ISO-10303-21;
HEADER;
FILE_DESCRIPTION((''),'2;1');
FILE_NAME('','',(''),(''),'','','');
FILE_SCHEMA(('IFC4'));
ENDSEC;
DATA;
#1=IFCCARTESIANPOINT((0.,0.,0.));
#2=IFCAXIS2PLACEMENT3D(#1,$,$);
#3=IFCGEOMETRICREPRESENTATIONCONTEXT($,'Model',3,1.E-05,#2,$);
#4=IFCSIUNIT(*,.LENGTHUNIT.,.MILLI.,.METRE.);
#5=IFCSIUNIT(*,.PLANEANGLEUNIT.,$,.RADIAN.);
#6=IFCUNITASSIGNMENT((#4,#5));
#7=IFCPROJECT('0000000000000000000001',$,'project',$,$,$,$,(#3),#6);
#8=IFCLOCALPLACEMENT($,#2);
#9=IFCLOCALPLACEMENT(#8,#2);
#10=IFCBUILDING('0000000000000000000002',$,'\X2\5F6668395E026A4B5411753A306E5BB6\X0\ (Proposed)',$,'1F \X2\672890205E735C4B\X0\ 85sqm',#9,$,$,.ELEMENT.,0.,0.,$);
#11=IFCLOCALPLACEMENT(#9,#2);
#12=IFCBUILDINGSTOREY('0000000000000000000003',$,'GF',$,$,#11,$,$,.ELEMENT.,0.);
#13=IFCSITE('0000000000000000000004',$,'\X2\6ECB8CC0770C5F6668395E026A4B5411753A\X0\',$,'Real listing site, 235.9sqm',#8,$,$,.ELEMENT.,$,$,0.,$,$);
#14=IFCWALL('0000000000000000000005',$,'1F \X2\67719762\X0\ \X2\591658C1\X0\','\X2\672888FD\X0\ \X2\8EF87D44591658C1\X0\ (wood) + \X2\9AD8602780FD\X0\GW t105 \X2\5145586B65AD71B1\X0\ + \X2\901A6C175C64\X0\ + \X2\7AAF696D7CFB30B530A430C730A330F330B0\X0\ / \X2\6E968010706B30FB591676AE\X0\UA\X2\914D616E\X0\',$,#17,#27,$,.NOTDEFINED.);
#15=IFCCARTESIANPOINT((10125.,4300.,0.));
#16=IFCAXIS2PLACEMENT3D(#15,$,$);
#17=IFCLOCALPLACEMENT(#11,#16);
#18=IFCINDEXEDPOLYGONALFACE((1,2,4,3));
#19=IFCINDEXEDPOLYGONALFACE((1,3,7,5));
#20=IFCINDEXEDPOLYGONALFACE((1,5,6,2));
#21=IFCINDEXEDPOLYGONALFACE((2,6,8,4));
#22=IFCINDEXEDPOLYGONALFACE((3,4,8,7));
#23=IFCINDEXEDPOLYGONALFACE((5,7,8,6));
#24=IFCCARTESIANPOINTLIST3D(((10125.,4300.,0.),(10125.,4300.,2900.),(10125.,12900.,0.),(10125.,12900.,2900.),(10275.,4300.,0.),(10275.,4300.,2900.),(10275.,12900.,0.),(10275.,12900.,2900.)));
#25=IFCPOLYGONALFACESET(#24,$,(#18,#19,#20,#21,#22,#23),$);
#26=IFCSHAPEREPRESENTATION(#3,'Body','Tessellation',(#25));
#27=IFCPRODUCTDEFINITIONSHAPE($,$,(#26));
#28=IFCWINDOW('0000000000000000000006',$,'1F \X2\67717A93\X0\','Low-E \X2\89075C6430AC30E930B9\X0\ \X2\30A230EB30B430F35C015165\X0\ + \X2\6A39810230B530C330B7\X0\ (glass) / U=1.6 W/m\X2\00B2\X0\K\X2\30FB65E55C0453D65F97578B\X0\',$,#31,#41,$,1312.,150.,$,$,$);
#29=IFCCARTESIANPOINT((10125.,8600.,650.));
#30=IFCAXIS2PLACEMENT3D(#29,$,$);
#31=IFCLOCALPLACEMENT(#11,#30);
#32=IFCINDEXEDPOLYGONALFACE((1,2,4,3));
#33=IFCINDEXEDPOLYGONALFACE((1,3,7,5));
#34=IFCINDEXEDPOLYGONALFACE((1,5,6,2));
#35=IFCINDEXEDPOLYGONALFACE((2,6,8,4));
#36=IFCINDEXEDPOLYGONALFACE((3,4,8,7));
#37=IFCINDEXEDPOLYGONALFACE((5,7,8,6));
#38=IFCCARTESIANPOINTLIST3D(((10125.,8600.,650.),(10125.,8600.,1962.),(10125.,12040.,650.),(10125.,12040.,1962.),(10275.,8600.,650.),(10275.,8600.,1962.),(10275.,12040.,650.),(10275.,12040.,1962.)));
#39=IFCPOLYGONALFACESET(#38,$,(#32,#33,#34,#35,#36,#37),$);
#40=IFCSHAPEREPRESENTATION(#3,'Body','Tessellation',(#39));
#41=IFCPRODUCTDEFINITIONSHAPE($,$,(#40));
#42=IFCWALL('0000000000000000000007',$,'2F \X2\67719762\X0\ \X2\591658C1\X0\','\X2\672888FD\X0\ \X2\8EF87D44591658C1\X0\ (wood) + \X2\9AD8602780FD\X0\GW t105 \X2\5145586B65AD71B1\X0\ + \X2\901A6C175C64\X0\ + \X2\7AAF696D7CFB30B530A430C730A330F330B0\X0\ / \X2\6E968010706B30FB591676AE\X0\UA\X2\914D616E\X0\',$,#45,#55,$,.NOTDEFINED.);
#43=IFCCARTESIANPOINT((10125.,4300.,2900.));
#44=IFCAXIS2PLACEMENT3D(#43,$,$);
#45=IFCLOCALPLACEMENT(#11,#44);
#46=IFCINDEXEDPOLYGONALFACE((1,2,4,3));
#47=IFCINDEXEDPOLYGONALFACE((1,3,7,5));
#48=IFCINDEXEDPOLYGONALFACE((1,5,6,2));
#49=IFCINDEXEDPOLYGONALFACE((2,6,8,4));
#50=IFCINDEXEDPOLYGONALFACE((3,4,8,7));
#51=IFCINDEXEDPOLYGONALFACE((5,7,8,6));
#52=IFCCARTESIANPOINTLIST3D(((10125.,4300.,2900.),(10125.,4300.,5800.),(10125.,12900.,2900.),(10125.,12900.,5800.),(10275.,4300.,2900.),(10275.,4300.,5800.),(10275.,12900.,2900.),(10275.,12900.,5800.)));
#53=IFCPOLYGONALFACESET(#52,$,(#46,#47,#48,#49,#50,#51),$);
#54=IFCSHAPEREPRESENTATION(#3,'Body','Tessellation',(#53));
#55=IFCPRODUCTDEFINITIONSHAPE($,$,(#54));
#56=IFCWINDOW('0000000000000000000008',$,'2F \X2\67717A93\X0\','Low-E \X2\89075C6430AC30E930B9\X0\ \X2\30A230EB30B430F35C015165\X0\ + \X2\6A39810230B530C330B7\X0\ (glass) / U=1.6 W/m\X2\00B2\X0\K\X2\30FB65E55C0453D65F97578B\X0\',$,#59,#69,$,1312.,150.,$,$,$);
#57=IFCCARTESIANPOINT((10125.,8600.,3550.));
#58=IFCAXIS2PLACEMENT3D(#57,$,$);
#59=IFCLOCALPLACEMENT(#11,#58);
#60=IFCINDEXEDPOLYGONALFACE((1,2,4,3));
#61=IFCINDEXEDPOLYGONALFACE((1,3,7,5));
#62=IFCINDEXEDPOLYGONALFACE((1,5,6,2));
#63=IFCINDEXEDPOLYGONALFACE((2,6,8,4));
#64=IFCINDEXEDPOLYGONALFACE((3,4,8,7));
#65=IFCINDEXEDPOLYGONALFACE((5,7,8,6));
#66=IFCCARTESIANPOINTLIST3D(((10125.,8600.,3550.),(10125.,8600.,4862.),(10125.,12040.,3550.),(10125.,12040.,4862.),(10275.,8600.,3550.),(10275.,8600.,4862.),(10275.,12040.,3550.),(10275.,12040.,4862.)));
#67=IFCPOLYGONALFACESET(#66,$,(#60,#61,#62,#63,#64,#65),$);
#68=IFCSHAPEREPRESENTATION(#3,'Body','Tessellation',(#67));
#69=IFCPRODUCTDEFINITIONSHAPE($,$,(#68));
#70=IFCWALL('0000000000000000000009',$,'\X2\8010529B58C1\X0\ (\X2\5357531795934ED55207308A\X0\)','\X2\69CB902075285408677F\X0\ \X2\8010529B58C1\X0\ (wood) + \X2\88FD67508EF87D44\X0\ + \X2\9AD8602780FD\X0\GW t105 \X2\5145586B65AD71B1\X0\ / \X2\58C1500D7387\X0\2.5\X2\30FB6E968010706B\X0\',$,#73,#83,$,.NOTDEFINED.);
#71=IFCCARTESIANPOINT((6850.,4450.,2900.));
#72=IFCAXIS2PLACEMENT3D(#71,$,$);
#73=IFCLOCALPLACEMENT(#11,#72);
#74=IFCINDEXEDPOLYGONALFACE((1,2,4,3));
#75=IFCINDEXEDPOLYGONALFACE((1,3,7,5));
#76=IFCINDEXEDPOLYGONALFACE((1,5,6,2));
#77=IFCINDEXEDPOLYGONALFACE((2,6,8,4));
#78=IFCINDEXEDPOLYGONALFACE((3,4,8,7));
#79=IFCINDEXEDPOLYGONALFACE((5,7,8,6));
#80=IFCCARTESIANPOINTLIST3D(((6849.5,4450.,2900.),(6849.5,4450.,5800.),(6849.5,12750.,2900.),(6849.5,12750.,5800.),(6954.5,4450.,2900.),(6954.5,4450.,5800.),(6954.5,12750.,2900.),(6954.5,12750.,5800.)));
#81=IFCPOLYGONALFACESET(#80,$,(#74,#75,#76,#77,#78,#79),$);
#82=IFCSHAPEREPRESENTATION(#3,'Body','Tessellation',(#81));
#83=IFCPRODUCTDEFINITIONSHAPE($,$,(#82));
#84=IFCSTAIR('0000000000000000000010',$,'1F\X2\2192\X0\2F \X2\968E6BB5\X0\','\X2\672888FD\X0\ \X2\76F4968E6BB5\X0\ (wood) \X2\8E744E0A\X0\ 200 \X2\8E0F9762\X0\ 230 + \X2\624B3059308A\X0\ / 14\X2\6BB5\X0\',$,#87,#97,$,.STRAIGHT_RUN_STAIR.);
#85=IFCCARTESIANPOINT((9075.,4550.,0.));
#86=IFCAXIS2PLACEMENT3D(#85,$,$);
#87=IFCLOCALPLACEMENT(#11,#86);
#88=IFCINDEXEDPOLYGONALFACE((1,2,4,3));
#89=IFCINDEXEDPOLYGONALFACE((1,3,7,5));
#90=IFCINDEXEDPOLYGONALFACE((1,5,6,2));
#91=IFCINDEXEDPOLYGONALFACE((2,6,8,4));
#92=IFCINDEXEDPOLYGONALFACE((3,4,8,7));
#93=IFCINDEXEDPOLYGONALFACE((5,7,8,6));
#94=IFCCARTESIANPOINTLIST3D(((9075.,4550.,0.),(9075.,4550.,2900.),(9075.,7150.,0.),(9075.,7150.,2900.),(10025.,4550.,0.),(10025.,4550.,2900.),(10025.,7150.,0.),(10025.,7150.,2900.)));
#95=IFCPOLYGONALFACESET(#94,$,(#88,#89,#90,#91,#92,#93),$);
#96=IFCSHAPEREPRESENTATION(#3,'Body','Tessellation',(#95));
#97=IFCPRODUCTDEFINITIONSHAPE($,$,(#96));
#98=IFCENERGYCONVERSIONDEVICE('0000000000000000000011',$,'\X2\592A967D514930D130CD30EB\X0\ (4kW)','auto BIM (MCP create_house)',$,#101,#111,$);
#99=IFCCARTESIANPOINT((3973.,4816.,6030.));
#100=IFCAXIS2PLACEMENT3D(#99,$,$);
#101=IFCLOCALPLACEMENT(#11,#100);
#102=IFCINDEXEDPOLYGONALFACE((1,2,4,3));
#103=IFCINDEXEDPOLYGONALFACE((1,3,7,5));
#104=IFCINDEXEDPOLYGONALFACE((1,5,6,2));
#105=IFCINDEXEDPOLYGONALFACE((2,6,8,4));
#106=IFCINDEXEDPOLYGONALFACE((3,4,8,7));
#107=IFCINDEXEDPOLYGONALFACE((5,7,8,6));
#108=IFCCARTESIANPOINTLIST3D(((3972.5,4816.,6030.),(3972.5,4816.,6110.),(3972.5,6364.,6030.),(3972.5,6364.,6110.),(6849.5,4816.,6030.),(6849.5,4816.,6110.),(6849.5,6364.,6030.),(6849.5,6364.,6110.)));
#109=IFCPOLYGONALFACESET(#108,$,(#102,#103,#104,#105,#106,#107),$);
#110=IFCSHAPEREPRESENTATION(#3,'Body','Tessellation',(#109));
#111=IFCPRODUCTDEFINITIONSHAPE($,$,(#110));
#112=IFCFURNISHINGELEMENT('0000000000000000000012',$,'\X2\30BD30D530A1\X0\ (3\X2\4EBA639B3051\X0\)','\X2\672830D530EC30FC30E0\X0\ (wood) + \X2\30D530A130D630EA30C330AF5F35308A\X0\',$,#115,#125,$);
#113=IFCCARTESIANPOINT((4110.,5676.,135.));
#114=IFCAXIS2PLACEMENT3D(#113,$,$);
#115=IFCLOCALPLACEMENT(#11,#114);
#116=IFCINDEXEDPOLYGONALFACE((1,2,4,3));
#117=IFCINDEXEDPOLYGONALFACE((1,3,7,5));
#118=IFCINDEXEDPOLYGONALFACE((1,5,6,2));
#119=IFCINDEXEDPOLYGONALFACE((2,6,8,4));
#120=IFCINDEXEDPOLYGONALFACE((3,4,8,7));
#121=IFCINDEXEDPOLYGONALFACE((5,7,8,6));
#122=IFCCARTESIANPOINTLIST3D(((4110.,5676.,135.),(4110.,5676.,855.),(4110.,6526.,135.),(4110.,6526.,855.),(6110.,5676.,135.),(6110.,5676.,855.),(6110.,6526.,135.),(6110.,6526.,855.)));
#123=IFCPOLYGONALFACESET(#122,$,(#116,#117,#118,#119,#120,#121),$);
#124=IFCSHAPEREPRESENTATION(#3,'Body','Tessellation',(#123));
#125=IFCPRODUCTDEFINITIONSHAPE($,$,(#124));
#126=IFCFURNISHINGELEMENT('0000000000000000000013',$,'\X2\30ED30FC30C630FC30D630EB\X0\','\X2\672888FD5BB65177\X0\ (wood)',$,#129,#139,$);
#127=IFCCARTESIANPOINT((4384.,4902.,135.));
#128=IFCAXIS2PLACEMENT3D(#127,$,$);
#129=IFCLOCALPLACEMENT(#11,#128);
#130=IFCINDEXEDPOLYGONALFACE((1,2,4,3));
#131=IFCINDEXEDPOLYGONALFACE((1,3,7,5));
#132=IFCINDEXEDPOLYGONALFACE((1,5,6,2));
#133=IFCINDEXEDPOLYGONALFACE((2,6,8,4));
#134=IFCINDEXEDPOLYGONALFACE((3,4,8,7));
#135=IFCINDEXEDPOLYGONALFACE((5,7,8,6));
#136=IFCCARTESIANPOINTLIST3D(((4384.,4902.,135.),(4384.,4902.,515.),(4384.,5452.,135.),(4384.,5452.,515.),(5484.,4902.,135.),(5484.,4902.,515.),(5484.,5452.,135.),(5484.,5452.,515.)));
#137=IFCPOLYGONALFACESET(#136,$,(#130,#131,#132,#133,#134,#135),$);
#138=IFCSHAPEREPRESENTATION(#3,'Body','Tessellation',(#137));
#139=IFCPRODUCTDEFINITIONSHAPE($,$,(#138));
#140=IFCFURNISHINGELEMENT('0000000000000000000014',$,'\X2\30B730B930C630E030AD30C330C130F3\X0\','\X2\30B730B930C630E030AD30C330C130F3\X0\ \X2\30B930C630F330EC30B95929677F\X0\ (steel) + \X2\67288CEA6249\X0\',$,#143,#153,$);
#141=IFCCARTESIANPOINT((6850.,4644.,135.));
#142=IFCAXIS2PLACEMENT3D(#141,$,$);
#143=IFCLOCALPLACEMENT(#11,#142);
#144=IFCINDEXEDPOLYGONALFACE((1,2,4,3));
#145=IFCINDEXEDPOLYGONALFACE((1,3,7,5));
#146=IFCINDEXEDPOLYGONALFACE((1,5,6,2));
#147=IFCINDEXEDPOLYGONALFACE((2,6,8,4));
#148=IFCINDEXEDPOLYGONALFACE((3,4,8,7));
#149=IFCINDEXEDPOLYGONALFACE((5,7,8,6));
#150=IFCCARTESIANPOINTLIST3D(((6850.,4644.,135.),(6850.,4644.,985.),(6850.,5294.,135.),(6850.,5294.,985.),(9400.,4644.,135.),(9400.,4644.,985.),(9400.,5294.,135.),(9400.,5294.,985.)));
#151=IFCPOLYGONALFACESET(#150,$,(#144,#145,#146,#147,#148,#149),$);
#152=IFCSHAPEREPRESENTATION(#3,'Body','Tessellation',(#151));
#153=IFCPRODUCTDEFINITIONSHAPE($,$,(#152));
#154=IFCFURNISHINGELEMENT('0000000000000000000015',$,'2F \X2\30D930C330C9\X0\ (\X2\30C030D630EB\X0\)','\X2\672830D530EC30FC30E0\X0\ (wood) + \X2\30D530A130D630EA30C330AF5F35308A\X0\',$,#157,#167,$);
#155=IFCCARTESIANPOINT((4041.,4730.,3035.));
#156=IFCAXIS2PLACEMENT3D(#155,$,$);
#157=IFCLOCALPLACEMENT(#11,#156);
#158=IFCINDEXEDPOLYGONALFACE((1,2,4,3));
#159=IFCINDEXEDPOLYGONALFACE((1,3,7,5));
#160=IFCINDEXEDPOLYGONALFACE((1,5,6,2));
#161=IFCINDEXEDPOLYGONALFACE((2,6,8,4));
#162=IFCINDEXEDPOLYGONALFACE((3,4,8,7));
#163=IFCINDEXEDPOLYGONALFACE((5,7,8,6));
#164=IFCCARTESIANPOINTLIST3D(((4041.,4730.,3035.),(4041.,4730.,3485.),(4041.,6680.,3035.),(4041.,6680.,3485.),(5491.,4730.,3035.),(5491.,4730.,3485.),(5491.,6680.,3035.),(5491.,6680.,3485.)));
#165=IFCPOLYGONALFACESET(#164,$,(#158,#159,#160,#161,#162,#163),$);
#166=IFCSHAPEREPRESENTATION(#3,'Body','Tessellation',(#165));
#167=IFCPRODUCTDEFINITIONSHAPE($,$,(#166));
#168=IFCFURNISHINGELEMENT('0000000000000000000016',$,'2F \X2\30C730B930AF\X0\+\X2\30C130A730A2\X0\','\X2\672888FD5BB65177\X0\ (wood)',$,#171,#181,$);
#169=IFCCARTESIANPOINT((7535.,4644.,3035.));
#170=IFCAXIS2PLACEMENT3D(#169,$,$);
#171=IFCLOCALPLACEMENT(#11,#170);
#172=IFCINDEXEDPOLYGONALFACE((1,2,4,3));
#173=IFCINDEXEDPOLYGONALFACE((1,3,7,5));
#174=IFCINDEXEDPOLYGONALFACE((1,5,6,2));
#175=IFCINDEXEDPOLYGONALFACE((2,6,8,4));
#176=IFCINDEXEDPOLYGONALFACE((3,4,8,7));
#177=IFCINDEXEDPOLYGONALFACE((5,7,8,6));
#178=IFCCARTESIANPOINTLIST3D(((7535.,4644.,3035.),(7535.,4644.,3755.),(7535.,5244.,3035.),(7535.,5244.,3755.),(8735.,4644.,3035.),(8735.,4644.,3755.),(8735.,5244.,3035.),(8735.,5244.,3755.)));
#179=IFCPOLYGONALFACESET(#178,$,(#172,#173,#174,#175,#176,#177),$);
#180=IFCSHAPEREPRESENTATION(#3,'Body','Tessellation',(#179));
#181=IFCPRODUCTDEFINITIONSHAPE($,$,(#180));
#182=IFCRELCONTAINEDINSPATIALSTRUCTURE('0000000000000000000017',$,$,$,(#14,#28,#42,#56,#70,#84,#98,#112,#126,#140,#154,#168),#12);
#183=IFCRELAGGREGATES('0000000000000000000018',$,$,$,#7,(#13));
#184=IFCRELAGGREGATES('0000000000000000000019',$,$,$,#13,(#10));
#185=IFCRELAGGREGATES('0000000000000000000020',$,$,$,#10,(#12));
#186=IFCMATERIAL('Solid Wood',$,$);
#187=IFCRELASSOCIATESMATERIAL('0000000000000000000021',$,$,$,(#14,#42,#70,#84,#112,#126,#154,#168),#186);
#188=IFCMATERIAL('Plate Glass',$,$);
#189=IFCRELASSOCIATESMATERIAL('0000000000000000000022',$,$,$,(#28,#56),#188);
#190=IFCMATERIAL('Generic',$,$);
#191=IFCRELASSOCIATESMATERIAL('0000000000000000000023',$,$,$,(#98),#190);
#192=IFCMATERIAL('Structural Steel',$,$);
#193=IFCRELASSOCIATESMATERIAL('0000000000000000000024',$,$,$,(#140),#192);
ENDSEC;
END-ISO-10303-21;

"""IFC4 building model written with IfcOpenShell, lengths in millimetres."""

from ifc_helpers import new_model, si_unit, frame, frame_2d, origin, place, context, project, spatial, rectangle, extrude, material, element, fill, save


model = new_model("IFC4")

# Units and contexts
model_context = context("Model", 3, precision=1e-05, world=origin())
ifc_project = project(units=[si_unit("LENGTHUNIT", "METRE", prefix="MILLI"), si_unit("PLANEANGLEUNIT", "RADIAN")], contexts=[model_context])

# Site, building, storey
site_placement = place(None, origin())
site = spatial("IfcSite", under=ifc_project, at=site_placement, Name="滋賀県彦根市橋向町", ObjectType="Real listing site, 235.9sqm", CompositionType="ELEMENT", RefElevation=0.0)
building_placement = place(site_placement, origin())
building = spatial("IfcBuilding", under=site, at=building_placement, Name="彦根市橋向町の家 (Proposed)", ObjectType="1F 木造平屋 85sqm", CompositionType="ELEMENT", ElevationOfRefHeight=0.0, ElevationOfTerrain=0.0)
storey_placement = place(building_placement, origin())
storey = spatial("IfcBuildingStorey", under=building, at=storey_placement, Name="GF", CompositionType="ELEMENT", Elevation=0.0)

# Wall, opening, window
ifc_material_1 = material(Name="Solid Wood")
wall_1_placement = place(storey_placement, frame((10125.0, 4300.0, 0.0)))
wall_1 = element("IfcWall", 1, at=wall_1_placement, inside=storey, material=ifc_material_1, Name="1F 東面 外壁", Description="木製 軸組外壁 (wood) + 高性能GW t105 充填断熱 + 通気層 + 窯業系サイディング / 準耐火・外皮UA配慮", PredefinedType="NOTDEFINED", context=model_context, shape_type="SweptSolid", body=[
    extrude(rectangle(XDim=150.0, YDim=8600.0, at=frame_2d((75.0, 4300.0))), frame((10125.0, 4300.0, 0.0)), (0.0, 0.0, 1.0), 2900.0),
])
opening_1_placement = place(storey_placement, frame((10125.0, 8600.0, 650.0)))
opening_1 = element("IfcOpeningElement", 2, at=opening_1_placement, cuts=wall_1, PredefinedType="NOTDEFINED", context=model_context, shape_type="SweptSolid", body=[
    extrude(rectangle(XDim=150.0, YDim=3440.0, at=frame_2d((75.0, 1720.0))), frame((10125.0, 8600.0, 650.0)), (0.0, 0.0, 1.0), 1312.0),
])
ifc_material_2 = material(Name="Plate Glass")
window_1_placement = place(storey_placement, frame((10125.0, 8600.0, 650.0)))
window_1 = element("IfcWindow", 3, at=window_1_placement, inside=storey, material=ifc_material_2, Name="1F 東窓", Description="Low-E 複層ガラス アルゴン封入 + 樹脂サッシ (glass) / U=1.6 W/m²K・日射取得型", OverallHeight=1312.0, OverallWidth=150.0, context=model_context, shape_type="SweptSolid", body=[
    extrude(rectangle(XDim=150.0, YDim=3440.0, at=frame_2d((75.0, 1720.0))), frame((10125.0, 8600.0, 650.0)), (0.0, 0.0, 1.0), 1312.0),
])
fill(opening_1, window_1)

# Wall, opening, window
wall_2_placement = place(storey_placement, frame((10125.0, 4300.0, 2900.0)))
wall_2 = element("IfcWall", 4, at=wall_2_placement, inside=storey, material=ifc_material_1, Name="2F 東面 外壁", Description="木製 軸組外壁 (wood) + 高性能GW t105 充填断熱 + 通気層 + 窯業系サイディング / 準耐火・外皮UA配慮", PredefinedType="NOTDEFINED", context=model_context, shape_type="SweptSolid", body=[
    extrude(rectangle(XDim=150.0, YDim=8600.0, at=frame_2d((75.0, 4300.0))), frame((10125.0, 4300.0, 2900.0)), (0.0, 0.0, 1.0), 2900.0),
])
opening_2_placement = place(storey_placement, frame((10125.0, 8600.0, 3550.0)))
opening_2 = element("IfcOpeningElement", 5, at=opening_2_placement, cuts=wall_2, PredefinedType="NOTDEFINED", context=model_context, shape_type="SweptSolid", body=[
    extrude(rectangle(XDim=150.0, YDim=3440.0, at=frame_2d((75.0, 1720.0))), frame((10125.0, 8600.0, 3550.0)), (0.0, 0.0, 1.0), 1312.0),
])
window_2_placement = place(storey_placement, frame((10125.0, 8600.0, 3550.0)))
window_2 = element("IfcWindow", 6, at=window_2_placement, inside=storey, material=ifc_material_2, Name="2F 東窓", Description="Low-E 複層ガラス アルゴン封入 + 樹脂サッシ (glass) / U=1.6 W/m²K・日射取得型", OverallHeight=1312.0, OverallWidth=150.0, context=model_context, shape_type="SweptSolid", body=[
    extrude(rectangle(XDim=150.0, YDim=3440.0, at=frame_2d((75.0, 1720.0))), frame((10125.0, 8600.0, 3550.0)), (0.0, 0.0, 1.0), 1312.0),
])
fill(opening_2, window_2)

# Wall
wall_3_placement = place(storey_placement, frame((6850.0, 4450.0, 2900.0)))
element("IfcWall", 7, at=wall_3_placement, inside=storey, material=ifc_material_1, Name="耐力壁 (南北間仕切り)", Description="構造用合板 耐力壁 (wood) + 製材軸組 + 高性能GW t105 充填断熱 / 壁倍率2.5・準耐火", PredefinedType="NOTDEFINED", context=model_context, shape_type="SweptSolid", body=[
    extrude(rectangle(XDim=105.0, YDim=8300.0, at=frame_2d((52.0, 4150.0))), frame((6850.0, 4450.0, 2900.0)), (0.0, 0.0, 1.0), 2900.0),
])

# Stair
stair_placement = place(storey_placement, frame((9075.0, 4550.0, 0.0)))
element("IfcStair", 8, at=stair_placement, inside=storey, material=ifc_material_1, Name="1F→2F 階段", Description="木製 直階段 (wood) 蹴上 200 踏面 230 + 手すり / 14段", PredefinedType="STRAIGHT_RUN_STAIR", context=model_context, shape_type="SweptSolid", body=[
    extrude(rectangle(XDim=950.0, YDim=2600.0, at=frame_2d((475.0, 1300.0))), frame((9075.0, 4550.0, 0.0)), (0.0, 0.0, 1.0), 2900.0),
])

# Energy conversion device
ifc_material_3 = material(Name="Generic")
energy_conversion_device_placement = place(storey_placement, frame((3973.0, 4816.0, 6030.0)))
element("IfcEnergyConversionDevice", 9, at=energy_conversion_device_placement, inside=storey, material=ifc_material_3, Name="太陽光パネル (4kW)", Description="auto BIM (MCP create_house)", context=model_context, shape_type="SweptSolid", body=[
    extrude(rectangle(XDim=2877.0, YDim=1548.0, at=frame_2d((1438.0, 774.0))), frame((3973.0, 4816.0, 6030.0)), (0.0, 0.0, 1.0), 80.0),
])

# Furnishing elements
furnishing_1_placement = place(storey_placement, frame((4110.0, 5676.0, 135.0)))
element("IfcFurnishingElement", 10, at=furnishing_1_placement, inside=storey, material=ifc_material_1, Name="ソファ (3人掛け)", Description="木フレーム (wood) + ファブリック張り", context=model_context, shape_type="SweptSolid", body=[
    extrude(rectangle(XDim=2000.0, YDim=850.0, at=frame_2d((1000.0, 425.0))), frame((4110.0, 5676.0, 135.0)), (0.0, 0.0, 1.0), 720.0),
])
furnishing_2_placement = place(storey_placement, frame((4384.0, 4902.0, 135.0)))
element("IfcFurnishingElement", 11, at=furnishing_2_placement, inside=storey, material=ifc_material_1, Name="ローテーブル", Description="木製家具 (wood)", context=model_context, shape_type="SweptSolid", body=[
    extrude(rectangle(XDim=1100.0, YDim=550.0, at=frame_2d((550.0, 275.0))), frame((4384.0, 4902.0, 135.0)), (0.0, 0.0, 1.0), 380.0),
])
ifc_material_4 = material(Name="Structural Steel")
furnishing_3_placement = place(storey_placement, frame((6850.0, 4644.0, 135.0)))
element("IfcFurnishingElement", 12, at=furnishing_3_placement, inside=storey, material=ifc_material_4, Name="システムキッチン", Description="システムキッチン ステンレス天板 (steel) + 木質扉", context=model_context, shape_type="SweptSolid", body=[
    extrude(rectangle(XDim=2550.0, YDim=650.0, at=frame_2d((1275.0, 325.0))), frame((6850.0, 4644.0, 135.0)), (0.0, 0.0, 1.0), 850.0),
])
furnishing_4_placement = place(storey_placement, frame((4041.0, 4730.0, 3035.0)))
element("IfcFurnishingElement", 13, at=furnishing_4_placement, inside=storey, material=ifc_material_1, Name="2F ベッド (ダブル)", Description="木フレーム (wood) + ファブリック張り", context=model_context, shape_type="SweptSolid", body=[
    extrude(rectangle(XDim=1450.0, YDim=1950.0, at=frame_2d((725.0, 975.0))), frame((4041.0, 4730.0, 3035.0)), (0.0, 0.0, 1.0), 450.0),
])
furnishing_5_placement = place(storey_placement, frame((7535.0, 4644.0, 3035.0)))
element("IfcFurnishingElement", 14, at=furnishing_5_placement, inside=storey, material=ifc_material_1, Name="2F デスク+チェア", Description="木製家具 (wood)", context=model_context, shape_type="SweptSolid", body=[
    extrude(rectangle(XDim=1200.0, YDim=600.0, at=frame_2d((600.0, 300.0))), frame((7535.0, 4644.0, 3035.0)), (0.0, 0.0, 1.0), 720.0),
])

save(model, "model.ifc")
